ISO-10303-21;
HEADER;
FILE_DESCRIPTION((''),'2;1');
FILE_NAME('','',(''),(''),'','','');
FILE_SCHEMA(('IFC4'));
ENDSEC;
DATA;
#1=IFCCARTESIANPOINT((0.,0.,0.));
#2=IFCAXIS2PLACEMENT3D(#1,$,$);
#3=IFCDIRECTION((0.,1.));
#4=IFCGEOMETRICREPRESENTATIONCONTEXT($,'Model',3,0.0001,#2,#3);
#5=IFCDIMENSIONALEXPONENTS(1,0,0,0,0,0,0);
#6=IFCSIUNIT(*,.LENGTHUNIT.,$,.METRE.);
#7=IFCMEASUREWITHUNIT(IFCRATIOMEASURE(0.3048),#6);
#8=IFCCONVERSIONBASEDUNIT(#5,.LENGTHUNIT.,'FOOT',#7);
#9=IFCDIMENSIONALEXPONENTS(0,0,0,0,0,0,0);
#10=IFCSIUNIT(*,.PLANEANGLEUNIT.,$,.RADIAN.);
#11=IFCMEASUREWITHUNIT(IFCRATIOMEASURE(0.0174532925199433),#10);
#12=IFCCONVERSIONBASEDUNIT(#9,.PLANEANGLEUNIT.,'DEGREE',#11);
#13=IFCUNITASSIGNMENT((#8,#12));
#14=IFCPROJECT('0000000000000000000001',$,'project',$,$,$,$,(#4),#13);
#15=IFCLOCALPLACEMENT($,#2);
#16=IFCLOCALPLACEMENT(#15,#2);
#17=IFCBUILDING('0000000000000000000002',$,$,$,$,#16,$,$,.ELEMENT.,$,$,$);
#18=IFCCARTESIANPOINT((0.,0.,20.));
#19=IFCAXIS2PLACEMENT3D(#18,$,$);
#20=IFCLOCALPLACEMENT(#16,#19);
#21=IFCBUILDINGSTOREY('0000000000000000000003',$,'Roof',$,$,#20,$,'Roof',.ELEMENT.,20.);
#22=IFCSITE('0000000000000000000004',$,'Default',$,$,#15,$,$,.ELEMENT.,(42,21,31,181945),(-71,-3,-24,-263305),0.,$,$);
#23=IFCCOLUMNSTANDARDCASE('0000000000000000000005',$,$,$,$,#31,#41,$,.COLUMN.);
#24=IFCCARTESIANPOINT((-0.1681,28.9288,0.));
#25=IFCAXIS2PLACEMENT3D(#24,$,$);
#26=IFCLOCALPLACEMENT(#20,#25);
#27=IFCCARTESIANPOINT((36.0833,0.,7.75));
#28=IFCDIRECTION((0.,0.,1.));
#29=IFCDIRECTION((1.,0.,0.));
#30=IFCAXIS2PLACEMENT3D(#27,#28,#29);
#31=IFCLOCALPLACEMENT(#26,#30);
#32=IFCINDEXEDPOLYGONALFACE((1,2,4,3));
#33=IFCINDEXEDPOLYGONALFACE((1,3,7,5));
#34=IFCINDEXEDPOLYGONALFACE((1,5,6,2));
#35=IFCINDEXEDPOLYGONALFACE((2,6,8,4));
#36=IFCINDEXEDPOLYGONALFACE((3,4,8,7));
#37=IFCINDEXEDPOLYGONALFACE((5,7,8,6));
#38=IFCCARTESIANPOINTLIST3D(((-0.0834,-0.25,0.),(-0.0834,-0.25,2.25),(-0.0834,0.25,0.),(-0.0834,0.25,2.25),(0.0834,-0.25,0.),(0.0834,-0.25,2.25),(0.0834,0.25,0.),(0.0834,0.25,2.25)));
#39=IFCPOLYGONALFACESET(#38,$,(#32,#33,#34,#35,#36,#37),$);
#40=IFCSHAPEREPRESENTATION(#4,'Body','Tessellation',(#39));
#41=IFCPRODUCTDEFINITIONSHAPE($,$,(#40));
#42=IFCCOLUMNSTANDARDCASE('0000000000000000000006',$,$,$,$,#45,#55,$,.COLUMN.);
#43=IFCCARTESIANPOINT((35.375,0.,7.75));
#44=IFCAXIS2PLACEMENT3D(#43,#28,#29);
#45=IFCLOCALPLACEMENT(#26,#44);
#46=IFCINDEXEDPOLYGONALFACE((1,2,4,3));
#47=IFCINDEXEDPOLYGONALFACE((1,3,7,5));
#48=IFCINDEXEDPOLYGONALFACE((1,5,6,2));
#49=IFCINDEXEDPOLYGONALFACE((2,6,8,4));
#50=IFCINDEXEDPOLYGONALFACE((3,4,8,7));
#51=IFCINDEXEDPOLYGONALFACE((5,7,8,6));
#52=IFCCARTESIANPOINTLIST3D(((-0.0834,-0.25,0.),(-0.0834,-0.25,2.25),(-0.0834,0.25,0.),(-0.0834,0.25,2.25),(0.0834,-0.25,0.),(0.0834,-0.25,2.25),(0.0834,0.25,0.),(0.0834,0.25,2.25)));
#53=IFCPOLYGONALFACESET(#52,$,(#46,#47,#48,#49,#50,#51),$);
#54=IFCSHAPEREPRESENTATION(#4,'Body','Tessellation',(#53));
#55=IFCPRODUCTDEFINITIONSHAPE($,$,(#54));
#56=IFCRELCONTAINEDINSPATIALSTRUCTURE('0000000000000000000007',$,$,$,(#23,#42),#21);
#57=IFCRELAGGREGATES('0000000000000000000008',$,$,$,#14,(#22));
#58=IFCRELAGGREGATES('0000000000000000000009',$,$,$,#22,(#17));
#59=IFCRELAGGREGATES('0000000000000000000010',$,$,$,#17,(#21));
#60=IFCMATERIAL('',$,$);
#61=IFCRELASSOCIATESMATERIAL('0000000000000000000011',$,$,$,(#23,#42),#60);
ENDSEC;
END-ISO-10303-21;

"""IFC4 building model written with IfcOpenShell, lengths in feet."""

from ifc_helpers import new_model, entity, si_unit, converted_unit, direction, frame, origin, place, context, project, spatial, rectangle, extrude, material, element, save


model = new_model("IFC4")

# Units and contexts
model_context = context("Model", 3, precision=0.0001, world=origin(), true_north=direction((0.0, 1.0)))
ifc_project = project(units=[converted_unit("LENGTHUNIT", "FOOT", entity("IfcRatioMeasure", 0.3048), si_unit("LENGTHUNIT", "METRE"), dimensions=[1, 0, 0, 0, 0, 0, 0]), converted_unit("PLANEANGLEUNIT", "DEGREE", entity("IfcRatioMeasure", 0.0174532925199433), si_unit("PLANEANGLEUNIT", "RADIAN"), dimensions=[0, 0, 0, 0, 0, 0, 0])], contexts=[model_context])

# Site, building, storey
site_placement = place(None, origin())
site = spatial("IfcSite", under=ifc_project, at=site_placement, Name="Default", CompositionType="ELEMENT", RefLatitude=(42, 21, 31, 181945), RefLongitude=(-71, -3, -24, -263305), RefElevation=0.0)
building_placement = place(site_placement, origin())
building = spatial("IfcBuilding", under=site, at=building_placement, CompositionType="ELEMENT")
storey_placement = place(building_placement, frame((0.0, 0.0, 20.0)))
storey = spatial("IfcBuildingStorey", under=building, at=storey_placement, Name="Roof", LongName="Roof", CompositionType="ELEMENT", Elevation=20.0)

# Columns
placement = place(storey_placement, frame((-0.1681, 28.9288, 0.0)))
ifc_material_1 = material(Name="")
for number, where, z_axis, x_axis in (
    (1, (36.0833, 0.0, 7.75), (0.0, 0.0, 1.0), (1.0, 0.0, 0.0)),
    (2, (35.375, 0.0, 7.75), (0.0, 0.0, 1.0), (1.0, 0.0, 0.0)),
):
    element("IfcColumnStandardCase", number, at=place(placement, frame(where, z_axis=z_axis, x_axis=x_axis)), inside=storey, material=ifc_material_1, PredefinedType="COLUMN", context=model_context, shape_type="SweptSolid", body=[
        extrude(rectangle(XDim=0.1667, YDim=0.5), origin(), (0.0, 0.0, 1.0), 2.25),
    ])

save(model, "model.ifc")
